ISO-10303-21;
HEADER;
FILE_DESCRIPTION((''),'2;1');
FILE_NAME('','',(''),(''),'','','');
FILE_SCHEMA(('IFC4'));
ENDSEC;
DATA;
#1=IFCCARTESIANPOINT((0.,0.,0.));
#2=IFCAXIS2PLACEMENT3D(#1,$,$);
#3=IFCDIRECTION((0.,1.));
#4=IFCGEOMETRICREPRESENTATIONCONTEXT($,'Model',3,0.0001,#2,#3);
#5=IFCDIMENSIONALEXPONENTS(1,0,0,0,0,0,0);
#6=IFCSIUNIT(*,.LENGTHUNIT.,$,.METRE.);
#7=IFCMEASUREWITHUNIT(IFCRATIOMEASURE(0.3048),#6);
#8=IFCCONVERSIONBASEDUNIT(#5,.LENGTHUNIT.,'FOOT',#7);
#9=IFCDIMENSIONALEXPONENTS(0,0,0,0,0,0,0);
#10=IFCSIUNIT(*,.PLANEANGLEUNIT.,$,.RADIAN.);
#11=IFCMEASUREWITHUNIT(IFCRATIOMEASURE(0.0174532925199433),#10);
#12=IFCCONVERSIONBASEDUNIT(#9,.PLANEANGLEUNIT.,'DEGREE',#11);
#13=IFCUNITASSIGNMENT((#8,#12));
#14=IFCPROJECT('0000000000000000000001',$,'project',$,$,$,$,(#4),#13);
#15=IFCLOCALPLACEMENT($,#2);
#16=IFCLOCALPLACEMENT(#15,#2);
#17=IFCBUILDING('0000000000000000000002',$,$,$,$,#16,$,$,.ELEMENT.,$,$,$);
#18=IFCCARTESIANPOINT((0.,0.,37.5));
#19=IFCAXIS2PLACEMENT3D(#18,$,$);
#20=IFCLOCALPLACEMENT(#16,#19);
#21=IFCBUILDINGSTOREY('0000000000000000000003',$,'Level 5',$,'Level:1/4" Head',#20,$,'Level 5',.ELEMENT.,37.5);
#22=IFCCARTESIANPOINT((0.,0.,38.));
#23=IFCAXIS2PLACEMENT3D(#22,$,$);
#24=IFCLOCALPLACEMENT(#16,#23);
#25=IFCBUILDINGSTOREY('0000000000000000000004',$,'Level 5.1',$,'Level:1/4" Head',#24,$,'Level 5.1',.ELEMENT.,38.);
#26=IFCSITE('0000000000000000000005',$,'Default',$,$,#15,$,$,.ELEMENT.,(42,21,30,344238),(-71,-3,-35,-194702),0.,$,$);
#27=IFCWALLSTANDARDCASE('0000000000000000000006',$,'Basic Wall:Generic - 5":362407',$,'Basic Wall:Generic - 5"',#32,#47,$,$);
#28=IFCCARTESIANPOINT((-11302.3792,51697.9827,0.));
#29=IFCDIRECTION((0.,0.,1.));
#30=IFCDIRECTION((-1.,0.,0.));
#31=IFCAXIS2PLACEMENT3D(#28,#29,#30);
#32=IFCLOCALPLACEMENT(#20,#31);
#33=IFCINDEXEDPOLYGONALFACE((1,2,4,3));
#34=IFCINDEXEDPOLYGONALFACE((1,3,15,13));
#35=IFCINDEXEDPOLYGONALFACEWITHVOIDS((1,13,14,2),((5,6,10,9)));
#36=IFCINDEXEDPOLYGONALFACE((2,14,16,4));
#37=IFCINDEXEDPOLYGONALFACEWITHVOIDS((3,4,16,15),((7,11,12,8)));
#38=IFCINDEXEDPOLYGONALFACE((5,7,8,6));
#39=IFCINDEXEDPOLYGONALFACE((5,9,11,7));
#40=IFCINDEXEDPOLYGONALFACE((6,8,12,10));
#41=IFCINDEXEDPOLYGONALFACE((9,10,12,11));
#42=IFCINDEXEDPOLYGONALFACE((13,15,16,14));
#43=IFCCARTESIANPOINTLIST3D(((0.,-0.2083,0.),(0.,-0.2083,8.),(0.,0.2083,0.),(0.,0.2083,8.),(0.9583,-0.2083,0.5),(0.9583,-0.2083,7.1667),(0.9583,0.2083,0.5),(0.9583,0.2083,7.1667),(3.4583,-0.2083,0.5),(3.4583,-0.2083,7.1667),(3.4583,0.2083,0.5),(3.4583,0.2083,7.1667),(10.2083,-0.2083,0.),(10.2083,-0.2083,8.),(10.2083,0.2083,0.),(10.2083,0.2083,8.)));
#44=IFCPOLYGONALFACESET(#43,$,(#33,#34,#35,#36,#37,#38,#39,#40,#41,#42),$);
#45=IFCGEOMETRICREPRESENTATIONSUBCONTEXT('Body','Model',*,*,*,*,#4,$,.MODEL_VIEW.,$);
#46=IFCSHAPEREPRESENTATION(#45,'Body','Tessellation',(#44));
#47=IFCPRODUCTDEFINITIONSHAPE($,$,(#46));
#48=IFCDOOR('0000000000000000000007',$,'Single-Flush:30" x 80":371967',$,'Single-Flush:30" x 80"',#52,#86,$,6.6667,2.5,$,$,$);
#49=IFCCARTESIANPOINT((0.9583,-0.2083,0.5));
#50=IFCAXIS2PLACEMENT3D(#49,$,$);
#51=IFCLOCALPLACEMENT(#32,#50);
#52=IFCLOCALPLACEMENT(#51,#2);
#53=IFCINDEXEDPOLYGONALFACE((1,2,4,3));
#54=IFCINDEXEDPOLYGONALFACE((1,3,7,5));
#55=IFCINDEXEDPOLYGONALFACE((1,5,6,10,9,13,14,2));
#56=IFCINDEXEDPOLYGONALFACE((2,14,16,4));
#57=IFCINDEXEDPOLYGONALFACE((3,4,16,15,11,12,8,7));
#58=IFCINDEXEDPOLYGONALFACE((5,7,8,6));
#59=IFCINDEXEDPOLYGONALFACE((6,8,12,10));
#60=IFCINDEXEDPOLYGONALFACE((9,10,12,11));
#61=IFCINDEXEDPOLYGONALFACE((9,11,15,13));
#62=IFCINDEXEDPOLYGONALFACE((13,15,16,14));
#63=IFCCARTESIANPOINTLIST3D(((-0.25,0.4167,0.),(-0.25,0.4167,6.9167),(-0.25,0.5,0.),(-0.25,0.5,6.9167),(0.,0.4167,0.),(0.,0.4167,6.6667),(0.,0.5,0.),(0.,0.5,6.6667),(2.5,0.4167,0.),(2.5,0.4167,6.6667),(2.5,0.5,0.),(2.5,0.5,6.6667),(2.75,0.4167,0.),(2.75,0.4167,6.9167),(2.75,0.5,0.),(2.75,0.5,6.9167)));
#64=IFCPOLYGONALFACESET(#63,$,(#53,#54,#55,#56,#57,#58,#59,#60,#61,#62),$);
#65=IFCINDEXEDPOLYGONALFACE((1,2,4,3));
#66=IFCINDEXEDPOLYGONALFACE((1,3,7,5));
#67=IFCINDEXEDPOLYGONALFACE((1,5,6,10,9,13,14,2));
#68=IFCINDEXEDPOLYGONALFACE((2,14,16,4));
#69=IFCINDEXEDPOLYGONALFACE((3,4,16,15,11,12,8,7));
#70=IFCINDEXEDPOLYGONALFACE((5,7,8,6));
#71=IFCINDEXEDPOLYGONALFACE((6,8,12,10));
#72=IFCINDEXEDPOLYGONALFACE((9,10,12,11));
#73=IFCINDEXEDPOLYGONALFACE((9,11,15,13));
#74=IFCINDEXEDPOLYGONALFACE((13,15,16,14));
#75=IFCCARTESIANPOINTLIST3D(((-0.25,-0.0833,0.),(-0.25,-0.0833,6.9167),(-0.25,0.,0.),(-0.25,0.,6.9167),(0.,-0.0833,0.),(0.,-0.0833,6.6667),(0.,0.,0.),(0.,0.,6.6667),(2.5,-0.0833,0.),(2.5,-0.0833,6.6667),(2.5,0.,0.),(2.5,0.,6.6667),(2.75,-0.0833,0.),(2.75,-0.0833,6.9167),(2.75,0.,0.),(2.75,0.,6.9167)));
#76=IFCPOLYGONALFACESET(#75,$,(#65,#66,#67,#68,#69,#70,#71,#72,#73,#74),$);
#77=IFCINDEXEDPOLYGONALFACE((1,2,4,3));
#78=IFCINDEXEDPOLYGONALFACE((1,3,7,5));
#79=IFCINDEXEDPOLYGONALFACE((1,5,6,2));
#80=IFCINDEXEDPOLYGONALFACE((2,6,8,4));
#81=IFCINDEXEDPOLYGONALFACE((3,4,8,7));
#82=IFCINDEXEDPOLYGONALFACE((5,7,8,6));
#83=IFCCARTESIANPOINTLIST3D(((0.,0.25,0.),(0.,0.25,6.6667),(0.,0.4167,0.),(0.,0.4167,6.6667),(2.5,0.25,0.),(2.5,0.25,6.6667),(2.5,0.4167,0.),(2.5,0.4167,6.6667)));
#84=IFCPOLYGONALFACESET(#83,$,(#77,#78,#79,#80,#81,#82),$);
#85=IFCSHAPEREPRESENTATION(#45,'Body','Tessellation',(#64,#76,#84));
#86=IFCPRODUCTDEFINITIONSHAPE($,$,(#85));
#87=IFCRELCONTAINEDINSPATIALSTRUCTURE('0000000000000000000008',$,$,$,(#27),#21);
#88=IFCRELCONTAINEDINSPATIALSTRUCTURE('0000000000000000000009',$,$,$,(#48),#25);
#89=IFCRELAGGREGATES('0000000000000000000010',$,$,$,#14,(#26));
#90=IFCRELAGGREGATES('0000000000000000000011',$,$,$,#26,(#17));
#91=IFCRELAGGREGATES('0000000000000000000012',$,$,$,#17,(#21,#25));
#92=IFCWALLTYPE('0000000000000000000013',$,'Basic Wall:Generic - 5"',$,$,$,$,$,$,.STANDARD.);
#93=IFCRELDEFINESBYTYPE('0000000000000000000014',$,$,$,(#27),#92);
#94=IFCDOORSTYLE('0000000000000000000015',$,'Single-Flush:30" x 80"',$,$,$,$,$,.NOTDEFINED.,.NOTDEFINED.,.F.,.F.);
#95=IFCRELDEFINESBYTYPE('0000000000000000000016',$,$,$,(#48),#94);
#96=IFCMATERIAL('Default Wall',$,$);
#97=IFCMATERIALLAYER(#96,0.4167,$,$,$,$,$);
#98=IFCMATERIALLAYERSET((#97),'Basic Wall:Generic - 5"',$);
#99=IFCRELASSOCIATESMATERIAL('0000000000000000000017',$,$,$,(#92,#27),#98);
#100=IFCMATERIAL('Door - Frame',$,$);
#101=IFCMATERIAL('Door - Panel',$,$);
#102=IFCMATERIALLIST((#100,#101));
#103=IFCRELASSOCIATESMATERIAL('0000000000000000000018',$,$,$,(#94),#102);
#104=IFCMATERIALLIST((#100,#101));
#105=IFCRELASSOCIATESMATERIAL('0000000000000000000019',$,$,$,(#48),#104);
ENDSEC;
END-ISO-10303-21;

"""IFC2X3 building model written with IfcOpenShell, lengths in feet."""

from ifc_helpers import new_model, entity, si_unit, converted_unit, direction, frame, frame_2d, origin, place, context, subcontext, project, spatial, polyline, rectangle, outline, extrude, source, transform, mapped, material, material_list, layer, layer_set, layer_usage, type_object, type_shapes, element, fill, save


model = new_model("IFC2X3")

# Units and contexts
model_context = context("Model", 3, precision=0.0001, world=origin(), true_north=direction((0.0, 1.0)))
body_context = subcontext(model_context, "Body", "Model", "MODEL_VIEW")
ifc_project = project(units=[converted_unit("LENGTHUNIT", "FOOT", entity("IfcRatioMeasure", 0.3048), si_unit("LENGTHUNIT", "METRE"), dimensions=[1, 0, 0, 0, 0, 0, 0]), converted_unit("PLANEANGLEUNIT", "DEGREE", entity("IfcRatioMeasure", 0.0174532925199433), si_unit("PLANEANGLEUNIT", "RADIAN"), dimensions=[0, 0, 0, 0, 0, 0, 0])], contexts=[model_context])

# Site, building, storey
site_placement = place(None, origin())
site = spatial("IfcSite", under=ifc_project, at=site_placement, Name="Default", CompositionType="ELEMENT", RefLatitude=(42, 21, 30, 344238), RefLongitude=(-71, -3, -35, -194702), RefElevation=0.0)
building_placement = place(site_placement, origin())
building = spatial("IfcBuilding", under=site, at=building_placement, CompositionType="ELEMENT")
storey_1_placement = place(building_placement, frame((0.0, 0.0, 37.5)))
storey_1 = spatial("IfcBuildingStorey", under=building, at=storey_1_placement, Name="Level 5", ObjectType="Level:1/4\" Head", LongName="Level 5", CompositionType="ELEMENT", Elevation=37.5)

# Shared definitions
ifc_material_1 = material(Name="Default Wall")
ifc_layer = layer(ifc_material_1, 0.4167)
ifc_layer_set = layer_set([ifc_layer], Name="Basic Wall:Generic - 5\"")
wall_type = type_object("IfcWallType", Name="Basic Wall:Generic - 5\"", PredefinedType="STANDARD", material=ifc_layer_set)

# Wall, opening
ifc_layer_usage_1 = layer_usage(ifc_layer_set, "AXIS2", "POSITIVE", -0.2083)
wall_1_placement = place(storey_1_placement, frame((-11302.3792, 51697.9827, 0.0), z_axis=(0.0, 0.0, 1.0), x_axis=(-1.0, 0.0, 0.0)))
wall_1 = element("IfcWallStandardCase", 1, at=wall_1_placement, inside=storey_1, type_object=wall_type, material=ifc_layer_usage_1, Name="Basic Wall:Generic - 5\":362407", ObjectType="Basic Wall:Generic - 5\"", context=body_context, shape_type="SweptSolid", body=[
    extrude(rectangle(XDim=10.2083, YDim=0.4167, at=frame_2d((5.1042, 0.0), x_axis=(-1.0, 0.0))), origin(), (0.0, 0.0, 1.0), 8.0),
])
opening_1_placement = place(wall_1_placement, frame((0.9583, -0.2083, 0.5)))
opening_1 = element("IfcOpeningElement", 2, at=opening_1_placement, cuts=wall_1, ObjectType="Opening", context=body_context, shape_type="SweptSolid", body=[
    extrude(rectangle(XDim=2.5, YDim=6.6667, at=frame_2d((3.3333, 1.25), x_axis=(0.0, 1.0))), frame((0.0, 0.0, 0.0), z_axis=(0.0, 1.0, 0.0), x_axis=(0.0, 0.0, 1.0)), (0.0, 0.0, 1.0), 0.4167),
])

# Shared definitions
storey_2_placement = place(building_placement, frame((0.0, 0.0, 38.0)))
storey_2 = spatial("IfcBuildingStorey", under=building, at=storey_2_placement, Name="Level 5.1", ObjectType="Level:1/4\" Head", LongName="Level 5.1", CompositionType="ELEMENT", Elevation=38.0)

# Door
ifc_material_2 = material(Name="Door - Frame")
ifc_material_3 = material(Name="Door - Panel")
ifc_material_list_1 = material_list([ifc_material_2, ifc_material_3])
ifc_material_list_2 = material_list([ifc_material_2, ifc_material_3])
door_style = type_object("IfcDoorStyle", Name="Single-Flush:30\" x 80\"", ConstructionType="NOTDEFINED", OperationType="NOTDEFINED", ParameterTakesPrecedence=False, Sizeable=False, material=ifc_material_list_2)
shared_shape = source(origin(), body_context, "Body", "SweptSolid", [
    extrude(outline(polyline([(-1.5, -3.5208), (1.5, -3.5208), (1.5, 3.3958), (1.25, 3.3958), (1.25, -3.2708), (-1.25, -3.2708), (-1.25, 3.3958), (-1.5, 3.3958), (-1.5, -3.5208)])), frame((1.25, 0.4167, 3.3958), z_axis=(0.0, 1.0, 0.0), x_axis=(1.0, 0.0, 0.0)), (0.0, 0.0, 1.0), 0.0833),
    extrude(outline(polyline([(-3.5208, -1.5), (3.3958, -1.5), (3.3958, -1.25), (-3.2708, -1.25), (-3.2708, 1.25), (3.3958, 1.25), (3.3958, 1.5), (-3.5208, 1.5), (-3.5208, -1.5)])), frame((1.25, -0.0833, 3.3958), z_axis=(0.0, 1.0, 0.0), x_axis=(0.0, 0.0, -1.0)), (0.0, 0.0, 1.0), 0.0833),
    extrude(rectangle(XDim=0.1667, YDim=2.5, at=frame_2d((0.0, 0.0), x_axis=(1.0, 0.0))), frame((1.25, 0.3333, 0.0), z_axis=(0.0, 0.0, 1.0), x_axis=(0.0, 1.0, 0.0)), (0.0, 0.0, 1.0), 6.6667),
])
type_shapes(door_style, [shared_shape])
door_placement = place(opening_1_placement, origin())
door = element("IfcDoor", 3, at=door_placement, inside=storey_2, type_object=door_style, material=ifc_material_list_1, Name="Single-Flush:30\" x 80\":371967", ObjectType="Single-Flush:30\" x 80\"", OverallHeight=6.6667, OverallWidth=2.5, context=body_context, shape_type="MappedRepresentation", body=[
    mapped(shared_shape, transform((0.0, 0.0, 0.0), scale=1.0)),
])
fill(opening_1, door)

save(model, "model.ifc")
